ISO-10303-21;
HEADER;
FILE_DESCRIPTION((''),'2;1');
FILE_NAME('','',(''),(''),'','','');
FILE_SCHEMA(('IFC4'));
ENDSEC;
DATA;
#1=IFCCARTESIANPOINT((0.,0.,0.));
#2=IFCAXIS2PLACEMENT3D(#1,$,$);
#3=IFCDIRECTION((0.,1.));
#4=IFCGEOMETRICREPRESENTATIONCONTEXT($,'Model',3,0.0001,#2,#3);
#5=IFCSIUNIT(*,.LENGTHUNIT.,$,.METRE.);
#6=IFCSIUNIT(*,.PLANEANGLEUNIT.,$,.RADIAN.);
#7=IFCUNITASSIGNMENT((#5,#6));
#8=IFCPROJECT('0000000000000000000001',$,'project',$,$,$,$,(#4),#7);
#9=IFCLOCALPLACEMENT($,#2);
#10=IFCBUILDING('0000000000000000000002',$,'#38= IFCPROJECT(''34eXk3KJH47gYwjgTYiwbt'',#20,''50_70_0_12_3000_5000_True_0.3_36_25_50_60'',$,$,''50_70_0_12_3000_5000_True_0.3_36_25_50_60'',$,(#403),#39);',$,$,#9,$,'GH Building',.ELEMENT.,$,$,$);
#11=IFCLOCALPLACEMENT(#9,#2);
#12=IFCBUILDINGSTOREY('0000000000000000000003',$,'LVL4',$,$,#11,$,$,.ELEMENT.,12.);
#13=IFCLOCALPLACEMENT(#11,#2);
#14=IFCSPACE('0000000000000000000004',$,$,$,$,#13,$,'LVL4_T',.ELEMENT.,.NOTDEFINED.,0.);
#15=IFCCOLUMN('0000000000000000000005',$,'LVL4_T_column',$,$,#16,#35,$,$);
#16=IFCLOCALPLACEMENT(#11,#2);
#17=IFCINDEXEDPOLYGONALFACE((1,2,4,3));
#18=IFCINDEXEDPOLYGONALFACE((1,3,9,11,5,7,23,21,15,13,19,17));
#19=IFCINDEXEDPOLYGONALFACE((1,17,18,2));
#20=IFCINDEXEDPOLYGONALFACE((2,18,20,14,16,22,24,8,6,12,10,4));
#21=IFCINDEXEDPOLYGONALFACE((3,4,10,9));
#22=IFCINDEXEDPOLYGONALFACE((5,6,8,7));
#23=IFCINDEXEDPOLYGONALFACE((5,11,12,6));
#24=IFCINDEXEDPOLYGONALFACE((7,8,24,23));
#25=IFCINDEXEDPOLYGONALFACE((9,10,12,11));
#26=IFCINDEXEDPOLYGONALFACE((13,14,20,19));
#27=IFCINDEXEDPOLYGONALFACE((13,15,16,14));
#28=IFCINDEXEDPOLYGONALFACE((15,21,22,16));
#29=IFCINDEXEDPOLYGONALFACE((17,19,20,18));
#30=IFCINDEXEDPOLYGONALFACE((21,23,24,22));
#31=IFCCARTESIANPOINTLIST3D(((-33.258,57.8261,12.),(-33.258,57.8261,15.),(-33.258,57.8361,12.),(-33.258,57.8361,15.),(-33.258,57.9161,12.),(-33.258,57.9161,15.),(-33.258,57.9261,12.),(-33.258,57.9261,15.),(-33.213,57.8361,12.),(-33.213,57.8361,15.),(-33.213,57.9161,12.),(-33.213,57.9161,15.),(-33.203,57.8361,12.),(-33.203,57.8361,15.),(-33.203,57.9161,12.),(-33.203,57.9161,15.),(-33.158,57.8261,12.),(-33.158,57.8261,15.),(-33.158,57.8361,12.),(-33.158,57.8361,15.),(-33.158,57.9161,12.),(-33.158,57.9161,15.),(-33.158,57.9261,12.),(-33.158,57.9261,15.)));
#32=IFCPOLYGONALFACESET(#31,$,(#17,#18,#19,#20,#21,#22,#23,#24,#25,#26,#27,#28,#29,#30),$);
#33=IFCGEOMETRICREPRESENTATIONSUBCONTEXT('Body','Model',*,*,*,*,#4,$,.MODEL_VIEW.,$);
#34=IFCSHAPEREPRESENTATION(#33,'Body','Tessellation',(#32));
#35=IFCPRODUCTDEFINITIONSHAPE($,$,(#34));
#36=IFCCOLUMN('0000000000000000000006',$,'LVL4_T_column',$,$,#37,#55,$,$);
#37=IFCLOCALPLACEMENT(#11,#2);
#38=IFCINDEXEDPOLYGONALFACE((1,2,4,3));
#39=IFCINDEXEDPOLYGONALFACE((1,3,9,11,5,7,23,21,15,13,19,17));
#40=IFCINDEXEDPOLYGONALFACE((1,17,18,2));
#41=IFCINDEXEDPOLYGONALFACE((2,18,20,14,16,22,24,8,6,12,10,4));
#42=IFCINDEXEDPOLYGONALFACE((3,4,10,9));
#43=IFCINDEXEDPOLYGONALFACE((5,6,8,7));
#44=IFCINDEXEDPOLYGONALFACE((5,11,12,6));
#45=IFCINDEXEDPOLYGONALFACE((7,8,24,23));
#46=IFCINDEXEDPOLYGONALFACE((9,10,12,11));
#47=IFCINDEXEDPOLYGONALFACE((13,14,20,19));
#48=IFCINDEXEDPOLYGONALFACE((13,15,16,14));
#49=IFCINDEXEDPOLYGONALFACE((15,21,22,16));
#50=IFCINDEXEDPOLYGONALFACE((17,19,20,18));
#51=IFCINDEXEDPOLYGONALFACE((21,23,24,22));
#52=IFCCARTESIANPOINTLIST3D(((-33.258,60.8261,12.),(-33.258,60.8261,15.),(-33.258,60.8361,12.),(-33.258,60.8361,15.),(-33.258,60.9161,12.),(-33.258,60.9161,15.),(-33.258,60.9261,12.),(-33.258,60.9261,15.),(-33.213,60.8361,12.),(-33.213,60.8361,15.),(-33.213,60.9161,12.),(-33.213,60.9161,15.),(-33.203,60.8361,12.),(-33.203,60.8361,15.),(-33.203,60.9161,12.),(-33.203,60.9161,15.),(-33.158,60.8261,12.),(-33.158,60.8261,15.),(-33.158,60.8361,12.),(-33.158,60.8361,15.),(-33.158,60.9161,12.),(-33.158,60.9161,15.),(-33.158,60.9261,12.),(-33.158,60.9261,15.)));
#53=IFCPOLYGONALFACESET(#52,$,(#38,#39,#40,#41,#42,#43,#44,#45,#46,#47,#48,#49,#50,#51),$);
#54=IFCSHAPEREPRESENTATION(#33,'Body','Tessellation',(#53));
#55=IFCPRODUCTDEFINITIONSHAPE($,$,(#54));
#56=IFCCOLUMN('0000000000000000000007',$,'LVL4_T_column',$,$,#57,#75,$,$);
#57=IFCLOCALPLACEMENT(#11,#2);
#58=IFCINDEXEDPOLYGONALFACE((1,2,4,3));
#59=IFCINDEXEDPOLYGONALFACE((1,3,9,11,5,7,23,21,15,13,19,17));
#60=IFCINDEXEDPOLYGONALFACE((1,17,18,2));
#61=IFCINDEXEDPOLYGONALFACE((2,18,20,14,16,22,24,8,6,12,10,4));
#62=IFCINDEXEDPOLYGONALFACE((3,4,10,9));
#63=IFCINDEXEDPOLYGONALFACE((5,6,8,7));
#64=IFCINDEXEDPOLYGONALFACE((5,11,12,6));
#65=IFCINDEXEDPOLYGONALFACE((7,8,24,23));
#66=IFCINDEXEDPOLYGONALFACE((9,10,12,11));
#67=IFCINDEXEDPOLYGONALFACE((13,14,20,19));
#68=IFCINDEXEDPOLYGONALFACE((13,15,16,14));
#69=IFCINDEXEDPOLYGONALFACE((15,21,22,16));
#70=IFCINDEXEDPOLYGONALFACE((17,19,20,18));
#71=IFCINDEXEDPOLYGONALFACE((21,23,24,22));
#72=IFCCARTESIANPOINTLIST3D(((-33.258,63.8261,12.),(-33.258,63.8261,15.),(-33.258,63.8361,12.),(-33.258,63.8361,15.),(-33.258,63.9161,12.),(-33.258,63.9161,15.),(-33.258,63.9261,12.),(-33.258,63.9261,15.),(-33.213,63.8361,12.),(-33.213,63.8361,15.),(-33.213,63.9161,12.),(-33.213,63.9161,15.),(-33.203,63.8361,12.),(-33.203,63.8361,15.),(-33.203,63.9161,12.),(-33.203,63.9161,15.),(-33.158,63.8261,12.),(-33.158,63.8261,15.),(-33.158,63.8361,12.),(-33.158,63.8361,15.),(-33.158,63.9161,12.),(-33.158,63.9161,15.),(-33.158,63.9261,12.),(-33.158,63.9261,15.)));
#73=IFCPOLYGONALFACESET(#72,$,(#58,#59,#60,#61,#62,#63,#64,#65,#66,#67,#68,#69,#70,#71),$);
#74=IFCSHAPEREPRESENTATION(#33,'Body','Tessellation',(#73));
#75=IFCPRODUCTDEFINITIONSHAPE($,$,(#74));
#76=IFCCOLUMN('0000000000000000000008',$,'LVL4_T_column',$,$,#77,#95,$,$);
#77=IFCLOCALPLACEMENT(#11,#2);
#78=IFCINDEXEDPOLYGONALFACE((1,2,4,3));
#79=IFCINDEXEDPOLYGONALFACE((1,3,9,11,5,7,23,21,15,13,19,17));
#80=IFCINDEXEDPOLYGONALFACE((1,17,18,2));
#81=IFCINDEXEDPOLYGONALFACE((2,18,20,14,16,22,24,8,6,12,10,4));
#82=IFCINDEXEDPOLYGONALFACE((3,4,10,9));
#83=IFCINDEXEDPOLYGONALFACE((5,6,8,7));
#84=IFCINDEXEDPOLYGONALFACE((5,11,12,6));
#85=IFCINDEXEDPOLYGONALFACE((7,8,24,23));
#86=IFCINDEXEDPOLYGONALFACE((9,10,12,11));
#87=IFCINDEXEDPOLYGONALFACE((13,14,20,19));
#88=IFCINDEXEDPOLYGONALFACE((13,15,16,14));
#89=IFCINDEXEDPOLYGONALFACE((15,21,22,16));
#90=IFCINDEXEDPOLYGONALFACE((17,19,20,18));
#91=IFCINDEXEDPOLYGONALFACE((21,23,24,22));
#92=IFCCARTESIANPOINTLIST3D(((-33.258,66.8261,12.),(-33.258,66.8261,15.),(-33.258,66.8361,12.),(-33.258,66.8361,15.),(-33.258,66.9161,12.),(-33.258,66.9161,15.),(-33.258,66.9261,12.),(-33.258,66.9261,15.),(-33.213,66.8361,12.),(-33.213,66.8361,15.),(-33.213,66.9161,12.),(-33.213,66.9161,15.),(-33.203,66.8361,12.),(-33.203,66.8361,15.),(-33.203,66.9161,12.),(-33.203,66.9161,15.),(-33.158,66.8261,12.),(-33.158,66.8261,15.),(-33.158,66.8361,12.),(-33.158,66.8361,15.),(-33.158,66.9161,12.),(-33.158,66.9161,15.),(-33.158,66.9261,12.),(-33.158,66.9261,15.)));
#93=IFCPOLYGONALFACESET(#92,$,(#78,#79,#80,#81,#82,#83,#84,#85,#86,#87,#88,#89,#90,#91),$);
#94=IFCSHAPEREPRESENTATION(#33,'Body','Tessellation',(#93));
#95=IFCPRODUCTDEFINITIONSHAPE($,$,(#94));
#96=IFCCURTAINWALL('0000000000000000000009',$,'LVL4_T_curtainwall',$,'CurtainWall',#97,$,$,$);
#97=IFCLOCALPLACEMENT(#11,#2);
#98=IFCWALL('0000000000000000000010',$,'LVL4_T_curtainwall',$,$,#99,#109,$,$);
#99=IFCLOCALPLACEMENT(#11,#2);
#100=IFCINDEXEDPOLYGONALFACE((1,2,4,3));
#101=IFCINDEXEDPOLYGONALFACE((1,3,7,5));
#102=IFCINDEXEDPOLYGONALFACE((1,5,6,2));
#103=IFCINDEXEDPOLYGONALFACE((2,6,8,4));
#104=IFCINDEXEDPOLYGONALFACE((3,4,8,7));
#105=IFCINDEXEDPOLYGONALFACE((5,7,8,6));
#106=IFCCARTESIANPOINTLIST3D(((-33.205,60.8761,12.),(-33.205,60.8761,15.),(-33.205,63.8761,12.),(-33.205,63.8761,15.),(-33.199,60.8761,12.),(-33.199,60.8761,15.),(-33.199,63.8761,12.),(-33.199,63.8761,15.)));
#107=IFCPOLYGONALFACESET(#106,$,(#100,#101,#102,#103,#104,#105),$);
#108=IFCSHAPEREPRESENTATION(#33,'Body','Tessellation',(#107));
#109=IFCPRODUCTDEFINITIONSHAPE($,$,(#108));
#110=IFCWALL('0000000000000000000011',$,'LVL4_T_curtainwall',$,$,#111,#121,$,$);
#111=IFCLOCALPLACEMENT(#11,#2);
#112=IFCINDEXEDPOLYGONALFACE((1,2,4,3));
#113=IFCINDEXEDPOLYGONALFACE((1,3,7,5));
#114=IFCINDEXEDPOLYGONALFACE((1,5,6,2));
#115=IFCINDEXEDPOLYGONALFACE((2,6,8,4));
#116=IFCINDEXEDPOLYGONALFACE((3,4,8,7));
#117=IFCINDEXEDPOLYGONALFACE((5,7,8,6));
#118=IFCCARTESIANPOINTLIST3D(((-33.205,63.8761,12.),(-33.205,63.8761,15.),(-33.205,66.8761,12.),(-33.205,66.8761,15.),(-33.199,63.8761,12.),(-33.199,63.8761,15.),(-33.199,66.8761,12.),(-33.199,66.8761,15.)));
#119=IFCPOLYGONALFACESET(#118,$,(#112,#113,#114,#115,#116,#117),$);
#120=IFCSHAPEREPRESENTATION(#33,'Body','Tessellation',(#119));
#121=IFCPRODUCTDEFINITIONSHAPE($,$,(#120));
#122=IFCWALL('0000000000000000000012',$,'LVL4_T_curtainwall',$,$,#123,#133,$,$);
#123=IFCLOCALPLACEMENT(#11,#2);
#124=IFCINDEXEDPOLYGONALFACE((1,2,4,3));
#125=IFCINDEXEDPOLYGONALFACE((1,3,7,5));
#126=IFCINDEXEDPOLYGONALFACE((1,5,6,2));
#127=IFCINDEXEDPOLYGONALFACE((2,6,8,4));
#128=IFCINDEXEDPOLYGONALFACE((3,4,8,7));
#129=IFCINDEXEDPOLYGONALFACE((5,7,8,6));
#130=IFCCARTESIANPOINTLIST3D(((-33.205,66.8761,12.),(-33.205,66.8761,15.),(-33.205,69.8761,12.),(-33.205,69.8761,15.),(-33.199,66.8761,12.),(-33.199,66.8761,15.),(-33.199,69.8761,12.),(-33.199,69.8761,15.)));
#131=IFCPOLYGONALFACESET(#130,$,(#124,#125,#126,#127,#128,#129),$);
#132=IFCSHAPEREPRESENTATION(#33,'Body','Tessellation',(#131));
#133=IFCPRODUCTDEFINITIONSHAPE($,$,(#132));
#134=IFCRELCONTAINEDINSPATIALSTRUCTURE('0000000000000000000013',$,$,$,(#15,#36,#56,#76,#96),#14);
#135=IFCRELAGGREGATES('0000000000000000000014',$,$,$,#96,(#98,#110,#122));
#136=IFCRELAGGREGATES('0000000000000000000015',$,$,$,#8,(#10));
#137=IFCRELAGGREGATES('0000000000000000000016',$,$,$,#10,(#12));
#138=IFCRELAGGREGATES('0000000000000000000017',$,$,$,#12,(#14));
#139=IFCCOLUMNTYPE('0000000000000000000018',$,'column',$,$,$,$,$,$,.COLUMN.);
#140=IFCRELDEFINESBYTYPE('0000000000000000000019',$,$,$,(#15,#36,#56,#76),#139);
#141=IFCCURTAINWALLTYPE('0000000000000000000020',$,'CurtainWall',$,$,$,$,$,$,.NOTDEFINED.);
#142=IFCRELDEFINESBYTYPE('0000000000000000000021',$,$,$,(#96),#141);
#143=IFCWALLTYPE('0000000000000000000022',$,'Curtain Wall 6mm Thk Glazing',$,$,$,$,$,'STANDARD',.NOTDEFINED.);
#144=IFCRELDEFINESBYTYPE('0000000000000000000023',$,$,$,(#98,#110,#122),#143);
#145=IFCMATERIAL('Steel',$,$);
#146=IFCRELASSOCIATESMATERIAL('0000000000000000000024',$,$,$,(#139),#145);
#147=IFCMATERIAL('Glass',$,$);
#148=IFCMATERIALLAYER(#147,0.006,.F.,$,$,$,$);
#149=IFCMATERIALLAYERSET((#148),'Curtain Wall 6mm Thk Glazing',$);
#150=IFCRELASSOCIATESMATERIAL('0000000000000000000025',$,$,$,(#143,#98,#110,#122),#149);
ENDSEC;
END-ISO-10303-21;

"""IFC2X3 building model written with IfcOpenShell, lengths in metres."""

from ifc_helpers import new_model, si_unit, direction, frame, frame_2d, origin, origin_2d, place, context, subcontext, project, spatial, rectangle, i_section, extrude, material, layer, layer_set, layer_usage, type_object, element, aggregate, save


model = new_model("IFC2X3")

# Units and contexts
model_context = context("Model", 3, precision=0.0001, world=origin(), true_north=direction((0.0, 1.0)))
body_context = subcontext(model_context, "Body", "Model", "MODEL_VIEW")
ifc_project = project(units=[si_unit("LENGTHUNIT", "METRE"), si_unit("PLANEANGLEUNIT", "RADIAN")], contexts=[model_context])

# Building, storey, space
building_placement = place(None, origin())
building = spatial("IfcBuilding", under=ifc_project, at=building_placement, Name="#38= IFCPROJECT('34eXk3KJH47gYwjgTYiwbt',#20,'50_70_0_12_3000_5000_True_0.3_36_25_50_60',$,$,'50_70_0_12_3000_5000_True_0.3_36_25_50_60',$,(#403),#39);", LongName="GH Building", CompositionType="ELEMENT")
storey_placement = place(building_placement, origin())
storey = spatial("IfcBuildingStorey", under=building, at=storey_placement, Name="LVL4", CompositionType="ELEMENT", Elevation=12.0)
space_placement = place(storey_placement, origin())
space = spatial("IfcSpace", under=storey, at=space_placement, LongName="LVL4_T", CompositionType="ELEMENT", InteriorOrExteriorSpace="NOTDEFINED", ElevationWithFlooring=0.0)

# Columns
ifc_material_1 = material(Name="Steel")
column_type = type_object("IfcColumnType", Name="column", PredefinedType="COLUMN", material=ifc_material_1)
for number, where, name in (
    (1, (-33.208, 57.8761, 12.0), "LVL4_T_column"),
    (2, (-33.208, 60.8761, 12.0), "LVL4_T_column"),
    (3, (-33.208, 63.8761, 12.0), "LVL4_T_column"),
    (4, (-33.208, 66.8761, 12.0), "LVL4_T_column"),
):
    element("IfcColumn", number, at=place(space_placement, frame(where)), inside=space, type_object=column_type, Name=name, context=body_context, shape_type="SweptSolid", body=[
        extrude(i_section(OverallWidth=0.1, OverallDepth=0.1, WebThickness=0.01, FlangeThickness=0.01, at=origin_2d()), origin(), (0.0, 0.0, 1.0), 3.0),
    ])

# Curtain wall, walls
curtain_wall_type = type_object("IfcCurtainWallType", Name="CurtainWall", PredefinedType="NOTDEFINED")
curtain_wall_placement = place(None, origin())
curtain_wall = element("IfcCurtainWall", 5, at=curtain_wall_placement, inside=space, type_object=curtain_wall_type, Name="LVL4_T_curtainwall", ObjectType="CurtainWall")
ifc_material_2 = material(Name="Glass")
ifc_layer = layer(ifc_material_2, 0.006, ventilated=False)
ifc_layer_set = layer_set([ifc_layer], Name="Curtain Wall 6mm Thk Glazing")
ifc_layer_usage_1 = layer_usage(ifc_layer_set, "AXIS2", "NEGATIVE", -0.003)
wall_type = type_object("IfcWallType", Name="Curtain Wall 6mm Thk Glazing", ElementType="STANDARD", PredefinedType="NOTDEFINED", material=ifc_layer_set)
wall_1_placement = place(curtain_wall_placement, frame((-33.208, 60.8761, 12.0), z_axis=(0.0, 0.0, 1.0), x_axis=(0.0, 1.0, 0.0)))
wall_1 = element("IfcWall", 6, at=wall_1_placement, type_object=wall_type, material=ifc_layer_usage_1, Name="LVL4_T_curtainwall", context=body_context, shape_type="SweptSolid", body=[
    extrude(rectangle(XDim=3.0, YDim=0.006, at=frame_2d((1.5, -0.006))), origin(), (0.0, 0.0, 1.0), 3.0),
])
ifc_layer_usage_2 = layer_usage(ifc_layer_set, "AXIS2", "NEGATIVE", -0.003)
wall_2_placement = place(curtain_wall_placement, frame((-33.208, 63.8761, 12.0), z_axis=(0.0, 0.0, 1.0), x_axis=(0.0, 1.0, 0.0)))
wall_2 = element("IfcWall", 7, at=wall_2_placement, type_object=wall_type, material=ifc_layer_usage_2, Name="LVL4_T_curtainwall", context=body_context, shape_type="SweptSolid", body=[
    extrude(rectangle(XDim=3.0, YDim=0.006, at=frame_2d((1.5, -0.006))), origin(), (0.0, 0.0, 1.0), 3.0),
])
ifc_layer_usage_3 = layer_usage(ifc_layer_set, "AXIS2", "NEGATIVE", -0.003)
wall_3_placement = place(curtain_wall_placement, frame((-33.208, 66.8761, 12.0), z_axis=(0.0, 0.0, 1.0), x_axis=(0.0, 1.0, 0.0)))
wall_3 = element("IfcWall", 8, at=wall_3_placement, type_object=wall_type, material=ifc_layer_usage_3, Name="LVL4_T_curtainwall", context=body_context, shape_type="SweptSolid", body=[
    extrude(rectangle(XDim=3.0, YDim=0.006, at=frame_2d((1.5, -0.006))), origin(), (0.0, 0.0, 1.0), 3.0),
])
aggregate(curtain_wall, [wall_1, wall_2, wall_3])

save(model, "model.ifc")
